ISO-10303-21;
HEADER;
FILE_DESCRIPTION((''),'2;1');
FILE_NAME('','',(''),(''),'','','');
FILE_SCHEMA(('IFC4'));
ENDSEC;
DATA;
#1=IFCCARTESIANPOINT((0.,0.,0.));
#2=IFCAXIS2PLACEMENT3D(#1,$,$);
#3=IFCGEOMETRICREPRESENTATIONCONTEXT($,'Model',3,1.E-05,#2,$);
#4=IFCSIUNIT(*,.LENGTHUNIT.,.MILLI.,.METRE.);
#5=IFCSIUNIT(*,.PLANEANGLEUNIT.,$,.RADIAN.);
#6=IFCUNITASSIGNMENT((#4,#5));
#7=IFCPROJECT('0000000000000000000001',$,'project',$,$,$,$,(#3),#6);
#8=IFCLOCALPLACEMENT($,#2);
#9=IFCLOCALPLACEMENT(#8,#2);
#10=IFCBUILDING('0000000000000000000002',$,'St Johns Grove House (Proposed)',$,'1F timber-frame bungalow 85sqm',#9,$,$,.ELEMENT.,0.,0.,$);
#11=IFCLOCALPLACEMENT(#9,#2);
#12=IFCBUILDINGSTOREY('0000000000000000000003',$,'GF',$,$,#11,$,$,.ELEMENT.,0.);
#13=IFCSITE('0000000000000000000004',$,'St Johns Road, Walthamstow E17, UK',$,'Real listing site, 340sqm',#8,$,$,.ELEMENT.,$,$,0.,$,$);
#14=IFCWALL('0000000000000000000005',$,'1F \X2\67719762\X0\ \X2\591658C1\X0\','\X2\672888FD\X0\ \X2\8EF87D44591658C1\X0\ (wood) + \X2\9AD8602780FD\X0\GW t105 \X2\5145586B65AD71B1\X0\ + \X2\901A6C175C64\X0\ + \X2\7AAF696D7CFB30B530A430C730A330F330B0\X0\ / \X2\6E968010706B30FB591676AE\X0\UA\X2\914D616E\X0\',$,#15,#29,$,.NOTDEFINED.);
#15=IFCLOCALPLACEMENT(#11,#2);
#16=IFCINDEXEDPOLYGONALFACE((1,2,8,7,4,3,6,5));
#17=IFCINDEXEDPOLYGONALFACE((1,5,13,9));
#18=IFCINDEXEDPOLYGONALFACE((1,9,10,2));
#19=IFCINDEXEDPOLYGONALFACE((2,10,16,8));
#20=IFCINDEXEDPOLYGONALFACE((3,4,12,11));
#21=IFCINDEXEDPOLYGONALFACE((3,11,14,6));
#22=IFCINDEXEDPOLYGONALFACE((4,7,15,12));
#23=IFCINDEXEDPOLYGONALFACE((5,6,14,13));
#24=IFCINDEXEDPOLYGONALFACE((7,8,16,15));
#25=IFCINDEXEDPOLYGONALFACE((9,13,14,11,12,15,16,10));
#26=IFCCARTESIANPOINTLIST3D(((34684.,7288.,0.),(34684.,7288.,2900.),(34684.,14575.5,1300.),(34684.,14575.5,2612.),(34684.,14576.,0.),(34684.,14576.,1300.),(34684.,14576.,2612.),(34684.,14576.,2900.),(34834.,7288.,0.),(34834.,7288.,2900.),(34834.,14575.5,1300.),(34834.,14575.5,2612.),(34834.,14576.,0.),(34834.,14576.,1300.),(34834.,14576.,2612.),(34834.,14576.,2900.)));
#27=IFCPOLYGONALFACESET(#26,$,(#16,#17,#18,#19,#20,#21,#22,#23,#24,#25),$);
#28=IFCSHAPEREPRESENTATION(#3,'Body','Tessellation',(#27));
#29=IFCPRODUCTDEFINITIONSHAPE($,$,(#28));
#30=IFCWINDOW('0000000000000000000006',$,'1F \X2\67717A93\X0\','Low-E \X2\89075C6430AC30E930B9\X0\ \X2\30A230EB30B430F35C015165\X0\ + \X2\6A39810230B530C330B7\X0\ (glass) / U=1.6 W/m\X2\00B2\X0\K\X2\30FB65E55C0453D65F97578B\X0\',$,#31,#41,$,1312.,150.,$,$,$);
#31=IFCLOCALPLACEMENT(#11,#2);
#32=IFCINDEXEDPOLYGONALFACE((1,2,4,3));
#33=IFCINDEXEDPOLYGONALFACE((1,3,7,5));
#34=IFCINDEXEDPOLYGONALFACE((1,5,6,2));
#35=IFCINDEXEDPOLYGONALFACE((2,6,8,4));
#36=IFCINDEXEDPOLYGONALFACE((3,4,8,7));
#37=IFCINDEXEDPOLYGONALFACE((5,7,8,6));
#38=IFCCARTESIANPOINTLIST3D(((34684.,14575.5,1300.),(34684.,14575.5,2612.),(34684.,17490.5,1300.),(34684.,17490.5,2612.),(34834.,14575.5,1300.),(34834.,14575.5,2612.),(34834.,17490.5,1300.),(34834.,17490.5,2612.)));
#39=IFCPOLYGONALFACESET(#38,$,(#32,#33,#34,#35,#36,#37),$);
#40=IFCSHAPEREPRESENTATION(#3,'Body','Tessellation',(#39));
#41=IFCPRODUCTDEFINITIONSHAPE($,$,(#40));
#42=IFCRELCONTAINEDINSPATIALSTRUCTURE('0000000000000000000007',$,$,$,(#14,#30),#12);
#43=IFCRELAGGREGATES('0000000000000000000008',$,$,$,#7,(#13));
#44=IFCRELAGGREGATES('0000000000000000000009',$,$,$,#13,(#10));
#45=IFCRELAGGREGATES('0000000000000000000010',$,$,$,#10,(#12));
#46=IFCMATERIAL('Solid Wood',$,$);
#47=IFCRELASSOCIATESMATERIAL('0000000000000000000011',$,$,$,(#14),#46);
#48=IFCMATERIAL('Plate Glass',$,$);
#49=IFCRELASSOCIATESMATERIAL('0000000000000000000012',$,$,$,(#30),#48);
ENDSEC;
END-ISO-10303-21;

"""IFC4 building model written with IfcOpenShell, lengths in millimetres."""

from ifc_helpers import new_model, si_unit, frame, frame_2d, origin, place, context, project, spatial, rectangle, extrude, material, element, fill, save


model = new_model("IFC4")

# Units and contexts
model_context = context("Model", 3, precision=1e-05, world=origin())
ifc_project = project(units=[si_unit("LENGTHUNIT", "METRE", prefix="MILLI"), si_unit("PLANEANGLEUNIT", "RADIAN")], contexts=[model_context])

# Site, building, storey
site_placement = place(None, origin())
site = spatial("IfcSite", under=ifc_project, at=site_placement, Name="St Johns Road, Walthamstow E17, UK", ObjectType="Real listing site, 340sqm", CompositionType="ELEMENT", RefElevation=0.0)
building_placement = place(site_placement, origin())
building = spatial("IfcBuilding", under=site, at=building_placement, Name="St Johns Grove House (Proposed)", ObjectType="1F timber-frame bungalow 85sqm", CompositionType="ELEMENT", ElevationOfRefHeight=0.0, ElevationOfTerrain=0.0)
storey_placement = place(building_placement, origin())
storey = spatial("IfcBuildingStorey", under=building, at=storey_placement, Name="GF", CompositionType="ELEMENT", Elevation=0.0)

# Shared definitions
ifc_material_1 = material(Name="Solid Wood")

# Wall, opening, window
wall_1_placement = place(storey_placement, frame((17342.0, 3644.0, 0.0)))
wall_1 = element("IfcWall", 1, at=wall_1_placement, inside=storey, material=ifc_material_1, Name="1F 東面 外壁", Description="木製 軸組外壁 (wood) + 高性能GW t105 充填断熱 + 通気層 + 窯業系サイディング / 準耐火・外皮UA配慮", PredefinedType="NOTDEFINED", context=model_context, shape_type="SweptSolid", body=[
    extrude(rectangle(XDim=150.0, YDim=7288.0, at=frame_2d((75.0, 3644.0))), frame((17342.0, 3644.0, 0.0)), (0.0, 0.0, 1.0), 2900.0),
])
opening_placement = place(storey_placement, frame((17342.0, 7288.0, 650.0)))
opening = element("IfcOpeningElement", 2, at=opening_placement, cuts=wall_1, PredefinedType="NOTDEFINED", context=model_context, shape_type="SweptSolid", body=[
    extrude(rectangle(XDim=150.0, YDim=2915.0, at=frame_2d((75.0, 1457.0))), frame((17342.0, 7288.0, 650.0)), (0.0, 0.0, 1.0), 1312.0),
])
ifc_material_2 = material(Name="Plate Glass")
window_placement = place(storey_placement, frame((17342.0, 7288.0, 650.0)))
window = element("IfcWindow", 3, at=window_placement, inside=storey, material=ifc_material_2, Name="1F 東窓", Description="Low-E 複層ガラス アルゴン封入 + 樹脂サッシ (glass) / U=1.6 W/m²K・日射取得型", OverallHeight=1312.0, OverallWidth=150.0, context=model_context, shape_type="SweptSolid", body=[
    extrude(rectangle(XDim=150.0, YDim=2915.0, at=frame_2d((75.0, 1457.0))), frame((17342.0, 7288.0, 650.0)), (0.0, 0.0, 1.0), 1312.0),
])
fill(opening, window)

save(model, "model.ifc")
